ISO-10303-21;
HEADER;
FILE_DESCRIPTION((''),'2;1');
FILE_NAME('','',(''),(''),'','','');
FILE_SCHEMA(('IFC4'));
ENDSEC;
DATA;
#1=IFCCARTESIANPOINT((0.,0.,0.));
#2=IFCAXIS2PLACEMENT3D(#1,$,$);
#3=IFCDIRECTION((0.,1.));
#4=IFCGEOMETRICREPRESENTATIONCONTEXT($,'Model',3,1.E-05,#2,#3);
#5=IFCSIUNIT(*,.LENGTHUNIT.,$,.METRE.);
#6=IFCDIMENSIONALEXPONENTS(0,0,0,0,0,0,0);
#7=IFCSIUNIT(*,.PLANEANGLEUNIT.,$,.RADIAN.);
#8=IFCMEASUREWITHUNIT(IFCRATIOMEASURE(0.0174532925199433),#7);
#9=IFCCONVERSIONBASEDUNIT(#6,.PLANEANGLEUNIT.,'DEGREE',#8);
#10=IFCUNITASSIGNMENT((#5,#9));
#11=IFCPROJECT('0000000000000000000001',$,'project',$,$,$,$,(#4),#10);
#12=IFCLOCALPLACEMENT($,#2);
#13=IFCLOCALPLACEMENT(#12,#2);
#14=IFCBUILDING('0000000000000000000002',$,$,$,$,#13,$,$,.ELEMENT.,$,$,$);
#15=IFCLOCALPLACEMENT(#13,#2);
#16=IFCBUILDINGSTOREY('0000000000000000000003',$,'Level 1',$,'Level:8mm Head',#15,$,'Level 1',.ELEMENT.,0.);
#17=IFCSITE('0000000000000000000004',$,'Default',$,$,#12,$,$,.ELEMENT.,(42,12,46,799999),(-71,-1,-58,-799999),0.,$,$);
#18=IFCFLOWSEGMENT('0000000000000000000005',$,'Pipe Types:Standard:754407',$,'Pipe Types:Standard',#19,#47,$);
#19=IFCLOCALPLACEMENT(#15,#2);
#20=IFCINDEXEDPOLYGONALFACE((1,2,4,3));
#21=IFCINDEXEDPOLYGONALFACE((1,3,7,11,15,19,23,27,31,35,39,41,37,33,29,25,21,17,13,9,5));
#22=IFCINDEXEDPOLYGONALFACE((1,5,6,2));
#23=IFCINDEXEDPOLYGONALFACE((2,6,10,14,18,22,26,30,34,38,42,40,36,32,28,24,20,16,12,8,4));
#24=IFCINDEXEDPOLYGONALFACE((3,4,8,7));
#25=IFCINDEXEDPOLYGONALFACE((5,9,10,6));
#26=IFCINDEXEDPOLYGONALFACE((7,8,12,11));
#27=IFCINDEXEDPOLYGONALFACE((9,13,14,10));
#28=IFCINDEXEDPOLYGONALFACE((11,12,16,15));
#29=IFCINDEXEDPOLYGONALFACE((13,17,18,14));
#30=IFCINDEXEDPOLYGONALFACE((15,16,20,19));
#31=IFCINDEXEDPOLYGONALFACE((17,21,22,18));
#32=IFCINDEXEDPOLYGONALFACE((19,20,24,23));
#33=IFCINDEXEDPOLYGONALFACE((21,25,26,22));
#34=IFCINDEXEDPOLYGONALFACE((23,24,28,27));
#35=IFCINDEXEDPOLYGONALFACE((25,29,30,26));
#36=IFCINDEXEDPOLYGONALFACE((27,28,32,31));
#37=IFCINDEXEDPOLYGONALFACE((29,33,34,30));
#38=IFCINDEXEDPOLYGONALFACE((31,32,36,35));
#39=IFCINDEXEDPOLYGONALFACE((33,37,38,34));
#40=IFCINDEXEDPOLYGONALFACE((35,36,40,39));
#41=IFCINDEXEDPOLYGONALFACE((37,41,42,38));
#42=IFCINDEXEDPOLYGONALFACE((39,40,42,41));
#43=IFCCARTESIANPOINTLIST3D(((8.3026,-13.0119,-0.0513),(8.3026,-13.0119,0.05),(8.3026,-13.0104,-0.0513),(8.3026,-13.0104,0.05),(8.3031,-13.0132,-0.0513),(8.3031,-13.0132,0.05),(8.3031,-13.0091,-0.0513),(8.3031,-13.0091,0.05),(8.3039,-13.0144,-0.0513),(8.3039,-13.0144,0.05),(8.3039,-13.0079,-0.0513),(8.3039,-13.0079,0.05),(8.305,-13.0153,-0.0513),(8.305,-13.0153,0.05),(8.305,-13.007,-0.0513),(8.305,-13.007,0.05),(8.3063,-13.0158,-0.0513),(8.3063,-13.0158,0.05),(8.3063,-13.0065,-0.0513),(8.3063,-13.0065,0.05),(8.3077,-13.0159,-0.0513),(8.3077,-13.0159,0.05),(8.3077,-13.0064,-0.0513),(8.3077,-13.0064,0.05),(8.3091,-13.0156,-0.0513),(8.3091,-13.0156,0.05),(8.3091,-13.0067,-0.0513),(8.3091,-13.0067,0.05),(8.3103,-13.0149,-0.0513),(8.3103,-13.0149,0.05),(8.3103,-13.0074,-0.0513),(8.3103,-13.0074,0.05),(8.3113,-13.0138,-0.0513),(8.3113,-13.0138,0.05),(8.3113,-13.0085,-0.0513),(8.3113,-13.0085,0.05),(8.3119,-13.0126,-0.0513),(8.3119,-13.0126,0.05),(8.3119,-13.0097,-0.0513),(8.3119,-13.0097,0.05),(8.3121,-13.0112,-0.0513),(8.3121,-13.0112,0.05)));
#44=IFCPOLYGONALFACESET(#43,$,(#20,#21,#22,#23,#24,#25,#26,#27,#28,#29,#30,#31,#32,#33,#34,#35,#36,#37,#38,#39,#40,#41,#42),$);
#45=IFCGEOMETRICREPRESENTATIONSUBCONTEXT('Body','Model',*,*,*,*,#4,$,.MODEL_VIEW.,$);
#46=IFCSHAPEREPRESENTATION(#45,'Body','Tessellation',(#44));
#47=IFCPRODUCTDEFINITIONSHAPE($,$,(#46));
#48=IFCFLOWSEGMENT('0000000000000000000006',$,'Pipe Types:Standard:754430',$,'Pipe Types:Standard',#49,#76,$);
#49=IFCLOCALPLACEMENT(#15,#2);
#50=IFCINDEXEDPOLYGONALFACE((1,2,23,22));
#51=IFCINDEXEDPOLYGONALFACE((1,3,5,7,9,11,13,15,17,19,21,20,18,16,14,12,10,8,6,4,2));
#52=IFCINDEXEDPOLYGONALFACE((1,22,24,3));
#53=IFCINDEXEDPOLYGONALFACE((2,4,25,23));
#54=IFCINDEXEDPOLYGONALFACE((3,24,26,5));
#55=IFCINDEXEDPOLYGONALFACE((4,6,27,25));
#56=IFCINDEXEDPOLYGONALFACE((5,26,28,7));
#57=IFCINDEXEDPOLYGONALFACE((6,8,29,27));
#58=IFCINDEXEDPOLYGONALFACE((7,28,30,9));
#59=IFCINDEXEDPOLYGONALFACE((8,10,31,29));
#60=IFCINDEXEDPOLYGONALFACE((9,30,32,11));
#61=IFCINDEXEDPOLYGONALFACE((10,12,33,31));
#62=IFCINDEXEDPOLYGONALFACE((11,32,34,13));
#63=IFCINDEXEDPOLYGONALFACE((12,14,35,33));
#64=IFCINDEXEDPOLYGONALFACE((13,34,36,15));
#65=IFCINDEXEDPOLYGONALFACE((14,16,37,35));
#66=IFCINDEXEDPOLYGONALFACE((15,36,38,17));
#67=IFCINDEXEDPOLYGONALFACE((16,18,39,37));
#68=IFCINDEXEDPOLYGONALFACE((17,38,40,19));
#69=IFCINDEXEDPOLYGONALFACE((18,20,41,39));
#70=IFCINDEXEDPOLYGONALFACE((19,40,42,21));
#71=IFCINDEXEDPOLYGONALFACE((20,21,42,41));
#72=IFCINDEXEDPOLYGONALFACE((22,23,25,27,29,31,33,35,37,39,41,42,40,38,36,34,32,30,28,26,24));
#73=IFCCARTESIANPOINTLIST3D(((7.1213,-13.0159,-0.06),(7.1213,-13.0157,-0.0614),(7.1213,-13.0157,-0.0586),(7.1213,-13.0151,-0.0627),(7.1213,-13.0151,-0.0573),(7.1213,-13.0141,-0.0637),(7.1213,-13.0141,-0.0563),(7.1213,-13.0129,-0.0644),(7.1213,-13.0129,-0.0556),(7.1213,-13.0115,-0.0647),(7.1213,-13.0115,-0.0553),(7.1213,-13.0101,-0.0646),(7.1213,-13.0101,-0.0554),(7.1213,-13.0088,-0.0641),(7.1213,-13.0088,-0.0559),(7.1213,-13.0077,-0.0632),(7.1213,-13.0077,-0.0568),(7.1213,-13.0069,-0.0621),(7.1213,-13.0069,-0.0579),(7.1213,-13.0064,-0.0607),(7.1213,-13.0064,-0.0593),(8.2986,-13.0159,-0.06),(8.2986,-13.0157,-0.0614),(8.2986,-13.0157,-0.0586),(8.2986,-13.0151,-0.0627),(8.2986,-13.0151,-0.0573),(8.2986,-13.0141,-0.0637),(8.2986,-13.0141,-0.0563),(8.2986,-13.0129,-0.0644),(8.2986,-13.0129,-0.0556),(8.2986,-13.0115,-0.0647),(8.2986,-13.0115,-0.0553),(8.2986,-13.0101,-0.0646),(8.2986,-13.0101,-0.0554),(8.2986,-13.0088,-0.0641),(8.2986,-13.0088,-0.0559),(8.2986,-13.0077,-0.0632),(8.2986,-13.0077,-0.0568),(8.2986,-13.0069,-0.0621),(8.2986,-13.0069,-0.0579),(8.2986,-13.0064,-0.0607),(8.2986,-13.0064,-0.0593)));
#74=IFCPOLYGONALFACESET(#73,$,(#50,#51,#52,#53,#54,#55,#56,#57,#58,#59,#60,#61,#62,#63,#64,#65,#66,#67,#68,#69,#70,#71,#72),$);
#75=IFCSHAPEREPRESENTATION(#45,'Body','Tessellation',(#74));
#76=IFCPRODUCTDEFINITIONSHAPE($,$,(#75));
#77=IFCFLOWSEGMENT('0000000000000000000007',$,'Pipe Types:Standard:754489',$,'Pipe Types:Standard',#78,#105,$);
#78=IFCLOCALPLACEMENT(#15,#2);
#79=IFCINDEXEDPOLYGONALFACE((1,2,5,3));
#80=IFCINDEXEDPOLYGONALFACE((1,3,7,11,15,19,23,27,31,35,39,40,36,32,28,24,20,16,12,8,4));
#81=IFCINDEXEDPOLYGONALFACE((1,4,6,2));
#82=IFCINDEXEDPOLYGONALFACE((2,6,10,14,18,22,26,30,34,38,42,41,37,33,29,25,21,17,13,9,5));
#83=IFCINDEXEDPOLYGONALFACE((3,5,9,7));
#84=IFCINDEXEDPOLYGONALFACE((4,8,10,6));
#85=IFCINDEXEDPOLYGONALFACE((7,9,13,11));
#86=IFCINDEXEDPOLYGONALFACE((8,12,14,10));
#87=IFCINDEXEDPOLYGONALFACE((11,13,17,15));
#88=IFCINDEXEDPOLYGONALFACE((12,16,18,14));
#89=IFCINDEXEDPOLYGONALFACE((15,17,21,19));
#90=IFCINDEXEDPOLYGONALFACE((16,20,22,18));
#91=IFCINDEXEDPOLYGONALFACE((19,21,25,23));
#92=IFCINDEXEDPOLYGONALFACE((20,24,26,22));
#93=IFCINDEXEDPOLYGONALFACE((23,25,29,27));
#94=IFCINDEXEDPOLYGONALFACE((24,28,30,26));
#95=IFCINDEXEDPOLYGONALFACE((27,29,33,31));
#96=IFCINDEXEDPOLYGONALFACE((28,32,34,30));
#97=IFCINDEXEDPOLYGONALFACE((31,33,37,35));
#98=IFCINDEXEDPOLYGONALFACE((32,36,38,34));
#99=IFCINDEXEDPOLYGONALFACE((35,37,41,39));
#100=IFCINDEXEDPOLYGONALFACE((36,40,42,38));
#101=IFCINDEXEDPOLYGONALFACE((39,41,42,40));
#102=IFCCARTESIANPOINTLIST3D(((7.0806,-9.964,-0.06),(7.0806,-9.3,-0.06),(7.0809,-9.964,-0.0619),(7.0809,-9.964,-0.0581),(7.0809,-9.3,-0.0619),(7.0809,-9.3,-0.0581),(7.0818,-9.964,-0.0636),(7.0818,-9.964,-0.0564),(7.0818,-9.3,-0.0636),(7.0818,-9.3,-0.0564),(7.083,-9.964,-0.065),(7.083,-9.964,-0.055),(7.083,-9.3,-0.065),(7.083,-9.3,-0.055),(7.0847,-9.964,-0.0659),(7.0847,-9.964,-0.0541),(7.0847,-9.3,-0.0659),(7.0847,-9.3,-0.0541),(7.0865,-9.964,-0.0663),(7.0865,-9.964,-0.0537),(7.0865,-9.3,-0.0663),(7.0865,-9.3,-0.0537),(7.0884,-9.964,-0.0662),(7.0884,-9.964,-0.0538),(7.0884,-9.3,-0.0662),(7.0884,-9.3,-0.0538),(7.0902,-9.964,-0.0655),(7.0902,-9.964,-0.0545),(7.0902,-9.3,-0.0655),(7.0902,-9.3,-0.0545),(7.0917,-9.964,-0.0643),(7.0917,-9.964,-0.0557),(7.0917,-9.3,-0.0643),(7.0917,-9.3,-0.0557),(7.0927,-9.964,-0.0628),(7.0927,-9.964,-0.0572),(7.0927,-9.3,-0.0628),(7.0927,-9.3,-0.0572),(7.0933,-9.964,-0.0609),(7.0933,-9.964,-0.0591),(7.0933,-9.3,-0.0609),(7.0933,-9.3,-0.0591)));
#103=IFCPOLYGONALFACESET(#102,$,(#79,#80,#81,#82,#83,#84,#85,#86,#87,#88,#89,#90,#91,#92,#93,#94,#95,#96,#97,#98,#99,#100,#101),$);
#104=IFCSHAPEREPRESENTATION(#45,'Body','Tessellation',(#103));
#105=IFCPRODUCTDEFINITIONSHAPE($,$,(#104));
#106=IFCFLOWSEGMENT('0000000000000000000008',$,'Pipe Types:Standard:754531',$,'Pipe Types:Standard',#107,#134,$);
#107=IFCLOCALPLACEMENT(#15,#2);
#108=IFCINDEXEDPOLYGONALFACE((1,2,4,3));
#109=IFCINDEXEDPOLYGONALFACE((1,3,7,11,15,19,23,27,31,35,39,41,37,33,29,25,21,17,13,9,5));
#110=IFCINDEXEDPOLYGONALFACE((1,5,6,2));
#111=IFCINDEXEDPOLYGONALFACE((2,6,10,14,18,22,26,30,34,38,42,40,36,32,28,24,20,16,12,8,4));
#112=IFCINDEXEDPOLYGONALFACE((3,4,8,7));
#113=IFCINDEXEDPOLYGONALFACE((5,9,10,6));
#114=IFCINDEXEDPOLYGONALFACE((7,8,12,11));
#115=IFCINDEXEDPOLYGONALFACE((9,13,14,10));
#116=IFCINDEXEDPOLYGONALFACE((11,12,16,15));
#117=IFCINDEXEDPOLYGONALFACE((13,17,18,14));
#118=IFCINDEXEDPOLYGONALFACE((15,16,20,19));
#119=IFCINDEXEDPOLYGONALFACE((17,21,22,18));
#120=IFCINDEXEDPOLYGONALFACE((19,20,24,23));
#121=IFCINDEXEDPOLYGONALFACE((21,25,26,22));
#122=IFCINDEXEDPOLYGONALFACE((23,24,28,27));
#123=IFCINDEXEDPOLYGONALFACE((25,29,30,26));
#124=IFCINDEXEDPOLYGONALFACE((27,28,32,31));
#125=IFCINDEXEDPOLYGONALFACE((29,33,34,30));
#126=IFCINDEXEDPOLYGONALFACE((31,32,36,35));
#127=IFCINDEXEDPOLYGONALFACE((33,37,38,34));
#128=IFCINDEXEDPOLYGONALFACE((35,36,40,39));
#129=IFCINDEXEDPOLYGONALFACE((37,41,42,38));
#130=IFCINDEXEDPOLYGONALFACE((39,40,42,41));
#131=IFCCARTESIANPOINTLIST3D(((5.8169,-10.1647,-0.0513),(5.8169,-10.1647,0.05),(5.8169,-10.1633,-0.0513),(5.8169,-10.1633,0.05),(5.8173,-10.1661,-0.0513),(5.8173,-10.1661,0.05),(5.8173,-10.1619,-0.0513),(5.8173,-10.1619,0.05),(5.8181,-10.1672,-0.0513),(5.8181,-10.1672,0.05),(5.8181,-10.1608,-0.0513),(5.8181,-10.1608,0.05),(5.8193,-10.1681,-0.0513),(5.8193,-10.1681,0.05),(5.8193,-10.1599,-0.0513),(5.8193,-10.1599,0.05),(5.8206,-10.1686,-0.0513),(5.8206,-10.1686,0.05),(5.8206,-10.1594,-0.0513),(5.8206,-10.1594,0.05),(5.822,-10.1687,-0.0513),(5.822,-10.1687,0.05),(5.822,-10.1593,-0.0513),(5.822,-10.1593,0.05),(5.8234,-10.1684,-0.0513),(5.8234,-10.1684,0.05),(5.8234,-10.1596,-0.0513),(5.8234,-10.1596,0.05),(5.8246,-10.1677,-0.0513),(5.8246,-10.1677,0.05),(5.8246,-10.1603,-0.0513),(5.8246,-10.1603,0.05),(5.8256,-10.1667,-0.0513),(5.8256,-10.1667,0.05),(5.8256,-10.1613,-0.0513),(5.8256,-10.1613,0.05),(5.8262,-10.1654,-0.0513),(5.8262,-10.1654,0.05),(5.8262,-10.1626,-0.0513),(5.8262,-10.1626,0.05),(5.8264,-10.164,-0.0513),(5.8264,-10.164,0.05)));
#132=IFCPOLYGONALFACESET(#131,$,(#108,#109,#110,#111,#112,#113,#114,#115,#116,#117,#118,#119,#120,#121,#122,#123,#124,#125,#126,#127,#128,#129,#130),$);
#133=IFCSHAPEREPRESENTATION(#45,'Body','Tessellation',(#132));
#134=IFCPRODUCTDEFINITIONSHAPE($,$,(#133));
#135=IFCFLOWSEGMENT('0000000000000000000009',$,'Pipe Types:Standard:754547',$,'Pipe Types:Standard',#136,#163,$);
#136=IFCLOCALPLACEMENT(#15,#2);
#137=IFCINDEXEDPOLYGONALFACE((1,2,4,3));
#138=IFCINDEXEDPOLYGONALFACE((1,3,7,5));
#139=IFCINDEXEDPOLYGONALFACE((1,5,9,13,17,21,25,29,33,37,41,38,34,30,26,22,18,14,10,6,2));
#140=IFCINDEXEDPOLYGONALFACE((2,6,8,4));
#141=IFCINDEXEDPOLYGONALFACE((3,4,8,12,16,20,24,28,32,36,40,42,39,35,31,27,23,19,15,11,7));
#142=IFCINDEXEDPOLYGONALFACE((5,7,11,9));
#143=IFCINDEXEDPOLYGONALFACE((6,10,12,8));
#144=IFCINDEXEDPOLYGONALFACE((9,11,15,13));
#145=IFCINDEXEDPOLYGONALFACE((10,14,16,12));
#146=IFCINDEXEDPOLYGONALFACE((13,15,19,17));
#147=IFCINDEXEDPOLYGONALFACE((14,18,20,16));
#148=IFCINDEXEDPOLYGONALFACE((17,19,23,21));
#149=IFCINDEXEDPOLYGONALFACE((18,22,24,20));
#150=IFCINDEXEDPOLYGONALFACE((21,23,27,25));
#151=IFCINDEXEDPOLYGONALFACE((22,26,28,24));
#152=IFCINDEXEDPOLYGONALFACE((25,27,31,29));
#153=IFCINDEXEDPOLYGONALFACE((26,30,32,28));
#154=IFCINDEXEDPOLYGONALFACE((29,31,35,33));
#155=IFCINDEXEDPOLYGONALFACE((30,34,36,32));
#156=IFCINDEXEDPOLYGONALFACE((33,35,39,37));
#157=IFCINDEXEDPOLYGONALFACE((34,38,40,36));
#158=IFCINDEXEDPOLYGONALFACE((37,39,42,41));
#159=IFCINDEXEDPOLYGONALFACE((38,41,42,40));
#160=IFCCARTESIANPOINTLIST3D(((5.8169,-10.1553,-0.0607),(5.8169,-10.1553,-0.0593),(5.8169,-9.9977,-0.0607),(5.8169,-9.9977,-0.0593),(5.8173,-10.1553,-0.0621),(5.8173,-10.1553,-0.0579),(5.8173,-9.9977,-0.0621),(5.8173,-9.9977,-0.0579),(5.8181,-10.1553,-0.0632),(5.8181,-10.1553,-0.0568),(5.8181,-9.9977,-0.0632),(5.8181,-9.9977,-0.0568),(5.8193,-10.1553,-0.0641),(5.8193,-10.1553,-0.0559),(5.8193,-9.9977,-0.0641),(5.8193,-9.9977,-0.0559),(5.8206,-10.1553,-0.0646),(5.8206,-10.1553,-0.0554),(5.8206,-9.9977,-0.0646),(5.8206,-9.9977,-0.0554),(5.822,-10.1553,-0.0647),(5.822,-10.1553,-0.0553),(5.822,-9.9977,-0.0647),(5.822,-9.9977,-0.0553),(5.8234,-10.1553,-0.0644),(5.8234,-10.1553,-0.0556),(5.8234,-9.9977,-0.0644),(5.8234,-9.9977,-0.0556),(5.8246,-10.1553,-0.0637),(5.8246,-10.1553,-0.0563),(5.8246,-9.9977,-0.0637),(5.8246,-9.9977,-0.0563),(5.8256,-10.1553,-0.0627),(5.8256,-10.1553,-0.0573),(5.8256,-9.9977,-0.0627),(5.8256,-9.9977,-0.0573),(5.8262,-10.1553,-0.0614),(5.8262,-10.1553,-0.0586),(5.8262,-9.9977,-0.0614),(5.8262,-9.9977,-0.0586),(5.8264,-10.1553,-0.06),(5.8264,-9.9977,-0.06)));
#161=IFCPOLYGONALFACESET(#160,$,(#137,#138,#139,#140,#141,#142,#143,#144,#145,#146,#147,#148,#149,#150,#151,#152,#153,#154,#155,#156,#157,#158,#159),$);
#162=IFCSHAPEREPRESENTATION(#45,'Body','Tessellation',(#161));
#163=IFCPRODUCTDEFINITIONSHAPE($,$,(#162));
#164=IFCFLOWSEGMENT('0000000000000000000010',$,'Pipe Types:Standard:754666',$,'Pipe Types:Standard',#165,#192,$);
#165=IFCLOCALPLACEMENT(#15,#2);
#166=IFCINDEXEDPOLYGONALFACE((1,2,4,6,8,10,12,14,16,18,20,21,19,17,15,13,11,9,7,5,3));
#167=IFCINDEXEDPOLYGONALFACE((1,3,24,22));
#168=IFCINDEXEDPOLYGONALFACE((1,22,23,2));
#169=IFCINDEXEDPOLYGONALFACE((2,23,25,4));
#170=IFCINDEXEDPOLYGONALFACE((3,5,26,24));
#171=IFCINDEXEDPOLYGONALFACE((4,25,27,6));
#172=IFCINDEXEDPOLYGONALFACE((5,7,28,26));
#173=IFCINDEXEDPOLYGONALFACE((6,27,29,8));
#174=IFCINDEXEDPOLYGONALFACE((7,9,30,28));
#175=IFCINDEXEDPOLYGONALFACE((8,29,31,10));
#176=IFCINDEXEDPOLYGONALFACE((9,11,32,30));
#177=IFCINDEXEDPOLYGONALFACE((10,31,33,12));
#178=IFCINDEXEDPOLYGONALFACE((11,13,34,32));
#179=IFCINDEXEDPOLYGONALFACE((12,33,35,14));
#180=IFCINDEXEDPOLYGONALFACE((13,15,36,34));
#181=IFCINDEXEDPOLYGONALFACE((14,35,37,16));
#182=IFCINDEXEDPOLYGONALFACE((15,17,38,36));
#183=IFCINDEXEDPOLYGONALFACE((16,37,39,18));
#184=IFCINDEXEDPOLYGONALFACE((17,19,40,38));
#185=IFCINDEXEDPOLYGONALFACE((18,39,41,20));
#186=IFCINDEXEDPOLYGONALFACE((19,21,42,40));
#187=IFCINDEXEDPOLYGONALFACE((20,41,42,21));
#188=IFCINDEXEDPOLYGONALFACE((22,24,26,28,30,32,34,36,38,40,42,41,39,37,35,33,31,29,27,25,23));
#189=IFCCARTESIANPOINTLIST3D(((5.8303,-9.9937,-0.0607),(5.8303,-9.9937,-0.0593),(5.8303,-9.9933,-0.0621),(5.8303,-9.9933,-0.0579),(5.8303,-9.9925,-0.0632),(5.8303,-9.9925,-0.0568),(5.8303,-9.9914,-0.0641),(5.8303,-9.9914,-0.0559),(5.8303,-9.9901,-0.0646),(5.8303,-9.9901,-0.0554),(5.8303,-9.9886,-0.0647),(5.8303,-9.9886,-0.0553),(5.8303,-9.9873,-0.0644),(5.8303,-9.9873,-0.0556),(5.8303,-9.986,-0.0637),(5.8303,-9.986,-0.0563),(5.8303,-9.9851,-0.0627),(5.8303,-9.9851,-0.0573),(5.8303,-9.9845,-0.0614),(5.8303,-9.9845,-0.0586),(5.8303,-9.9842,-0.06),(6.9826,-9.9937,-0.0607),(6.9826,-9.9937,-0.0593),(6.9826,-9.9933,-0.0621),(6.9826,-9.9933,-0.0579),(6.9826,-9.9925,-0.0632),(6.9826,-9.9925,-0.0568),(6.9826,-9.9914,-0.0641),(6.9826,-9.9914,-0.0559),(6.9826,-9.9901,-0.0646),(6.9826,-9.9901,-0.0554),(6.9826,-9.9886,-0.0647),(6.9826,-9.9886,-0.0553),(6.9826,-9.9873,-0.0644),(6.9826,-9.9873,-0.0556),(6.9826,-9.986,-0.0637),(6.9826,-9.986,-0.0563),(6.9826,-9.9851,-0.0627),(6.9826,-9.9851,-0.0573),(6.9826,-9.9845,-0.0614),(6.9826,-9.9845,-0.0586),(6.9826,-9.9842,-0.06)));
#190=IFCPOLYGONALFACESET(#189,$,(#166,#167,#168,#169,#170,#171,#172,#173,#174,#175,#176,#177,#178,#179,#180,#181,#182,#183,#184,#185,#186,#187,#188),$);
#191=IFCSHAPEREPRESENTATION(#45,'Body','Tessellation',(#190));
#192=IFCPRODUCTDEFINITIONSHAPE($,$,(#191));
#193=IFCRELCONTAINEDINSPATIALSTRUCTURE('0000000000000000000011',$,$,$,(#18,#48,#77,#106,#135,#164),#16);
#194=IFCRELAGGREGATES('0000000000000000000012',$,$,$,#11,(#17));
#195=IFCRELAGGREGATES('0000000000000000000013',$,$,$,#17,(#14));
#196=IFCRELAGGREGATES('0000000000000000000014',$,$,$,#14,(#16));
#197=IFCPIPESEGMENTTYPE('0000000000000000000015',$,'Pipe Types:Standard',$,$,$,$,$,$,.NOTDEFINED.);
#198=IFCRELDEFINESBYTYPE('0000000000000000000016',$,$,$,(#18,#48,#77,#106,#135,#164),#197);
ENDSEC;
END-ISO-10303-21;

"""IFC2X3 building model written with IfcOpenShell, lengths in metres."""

from ifc_helpers import new_model, entity, si_unit, converted_unit, direction, frame, frame_2d, origin, origin_2d_with_axis, place, context, subcontext, project, spatial, circle, extrude, type_object, element, save


model = new_model("IFC2X3")

# Units and contexts
model_context = context("Model", 3, precision=1e-05, world=origin(), true_north=direction((0.0, 1.0)))
body_context = subcontext(model_context, "Body", "Model", "MODEL_VIEW")
ifc_project = project(units=[si_unit("LENGTHUNIT", "METRE"), converted_unit("PLANEANGLEUNIT", "DEGREE", entity("IfcRatioMeasure", 0.0174532925199433), si_unit("PLANEANGLEUNIT", "RADIAN"), dimensions=[0, 0, 0, 0, 0, 0, 0])], contexts=[model_context])

# Site, building, storey
site_placement = place(None, origin())
site = spatial("IfcSite", under=ifc_project, at=site_placement, Name="Default", CompositionType="ELEMENT", RefLatitude=(42, 12, 46, 799999), RefLongitude=(-71, -1, -58, -799999), RefElevation=0.0)
building_placement = place(site_placement, origin())
building = spatial("IfcBuilding", under=site, at=building_placement, CompositionType="ELEMENT")
storey_placement = place(building_placement, origin())
storey = spatial("IfcBuildingStorey", under=building, at=storey_placement, Name="Level 1", ObjectType="Level:8mm Head", LongName="Level 1", CompositionType="ELEMENT", Elevation=0.0)

# Flow segments
pipe_segment_type = type_object("IfcPipeSegmentType", Name="Pipe Types:Standard", PredefinedType="NOTDEFINED")
flow_segment_1_placement = place(storey_placement, origin())
element("IfcFlowSegment", 1, at=flow_segment_1_placement, inside=storey, type_object=pipe_segment_type, Name="Pipe Types:Standard:754407", ObjectType="Pipe Types:Standard", context=body_context, shape_type="SweptSolid", body=[
    extrude(circle(Radius=0.0048, at=origin_2d_with_axis()), frame((8.3074, -13.0112, -0.0513)), (0.0, 0.0, 1.0), 0.1013),
])
flow_segment_2_placement = place(storey_placement, origin())
element("IfcFlowSegment", 2, at=flow_segment_2_placement, inside=storey, type_object=pipe_segment_type, Name="Pipe Types:Standard:754430", ObjectType="Pipe Types:Standard", context=body_context, shape_type="SweptSolid", body=[
    extrude(circle(Radius=0.0048, at=frame_2d((0.0, 0.0), x_axis=(1.0, 0.0))), frame((7.1213, -13.0112, -0.06), z_axis=(1.0, 0.0, 0.0), x_axis=(0.0, -1.0, 0.0)), (0.0, 0.0, 1.0), 1.1774),
])
flow_segment_3_placement = place(storey_placement, origin())
element("IfcFlowSegment", 3, at=flow_segment_3_placement, inside=storey, type_object=pipe_segment_type, Name="Pipe Types:Standard:754489", ObjectType="Pipe Types:Standard", context=body_context, shape_type="SweptSolid", body=[
    extrude(circle(Radius=0.0063, at=frame_2d((0.0, 0.0), x_axis=(1.0, 0.0))), frame((7.087, -9.964, -0.06), z_axis=(0.0, 1.0, 0.0), x_axis=(-1.0, 0.0, 0.0)), (0.0, 0.0, 1.0), 0.664),
])
flow_segment_4_placement = place(storey_placement, origin())
element("IfcFlowSegment", 4, at=flow_segment_4_placement, inside=storey, type_object=pipe_segment_type, Name="Pipe Types:Standard:754531", ObjectType="Pipe Types:Standard", context=body_context, shape_type="SweptSolid", body=[
    extrude(circle(Radius=0.0048, at=origin_2d_with_axis()), frame((5.8216, -10.164, -0.0513)), (0.0, 0.0, 1.0), 0.1013),
])
flow_segment_5_placement = place(storey_placement, origin())
element("IfcFlowSegment", 5, at=flow_segment_5_placement, inside=storey, type_object=pipe_segment_type, Name="Pipe Types:Standard:754547", ObjectType="Pipe Types:Standard", context=body_context, shape_type="SweptSolid", body=[
    extrude(circle(Radius=0.0048, at=origin_2d_with_axis()), frame((5.8216, -10.1553, -0.06), z_axis=(0.0, 1.0, 0.0), x_axis=(1.0, 0.0, 0.0)), (0.0, 0.0, 1.0), 0.1576),
])
flow_segment_6_placement = place(storey_placement, origin())
element("IfcFlowSegment", 6, at=flow_segment_6_placement, inside=storey, type_object=pipe_segment_type, Name="Pipe Types:Standard:754666", ObjectType="Pipe Types:Standard", context=body_context, shape_type="SweptSolid", body=[
    extrude(circle(Radius=0.0048, at=frame_2d((0.0, 0.0), x_axis=(1.0, 0.0))), frame((5.8303, -9.989, -0.06), z_axis=(1.0, 0.0, 0.0), x_axis=(0.0, 1.0, 0.0)), (0.0, 0.0, 1.0), 1.1522),
])

save(model, "model.ifc")
